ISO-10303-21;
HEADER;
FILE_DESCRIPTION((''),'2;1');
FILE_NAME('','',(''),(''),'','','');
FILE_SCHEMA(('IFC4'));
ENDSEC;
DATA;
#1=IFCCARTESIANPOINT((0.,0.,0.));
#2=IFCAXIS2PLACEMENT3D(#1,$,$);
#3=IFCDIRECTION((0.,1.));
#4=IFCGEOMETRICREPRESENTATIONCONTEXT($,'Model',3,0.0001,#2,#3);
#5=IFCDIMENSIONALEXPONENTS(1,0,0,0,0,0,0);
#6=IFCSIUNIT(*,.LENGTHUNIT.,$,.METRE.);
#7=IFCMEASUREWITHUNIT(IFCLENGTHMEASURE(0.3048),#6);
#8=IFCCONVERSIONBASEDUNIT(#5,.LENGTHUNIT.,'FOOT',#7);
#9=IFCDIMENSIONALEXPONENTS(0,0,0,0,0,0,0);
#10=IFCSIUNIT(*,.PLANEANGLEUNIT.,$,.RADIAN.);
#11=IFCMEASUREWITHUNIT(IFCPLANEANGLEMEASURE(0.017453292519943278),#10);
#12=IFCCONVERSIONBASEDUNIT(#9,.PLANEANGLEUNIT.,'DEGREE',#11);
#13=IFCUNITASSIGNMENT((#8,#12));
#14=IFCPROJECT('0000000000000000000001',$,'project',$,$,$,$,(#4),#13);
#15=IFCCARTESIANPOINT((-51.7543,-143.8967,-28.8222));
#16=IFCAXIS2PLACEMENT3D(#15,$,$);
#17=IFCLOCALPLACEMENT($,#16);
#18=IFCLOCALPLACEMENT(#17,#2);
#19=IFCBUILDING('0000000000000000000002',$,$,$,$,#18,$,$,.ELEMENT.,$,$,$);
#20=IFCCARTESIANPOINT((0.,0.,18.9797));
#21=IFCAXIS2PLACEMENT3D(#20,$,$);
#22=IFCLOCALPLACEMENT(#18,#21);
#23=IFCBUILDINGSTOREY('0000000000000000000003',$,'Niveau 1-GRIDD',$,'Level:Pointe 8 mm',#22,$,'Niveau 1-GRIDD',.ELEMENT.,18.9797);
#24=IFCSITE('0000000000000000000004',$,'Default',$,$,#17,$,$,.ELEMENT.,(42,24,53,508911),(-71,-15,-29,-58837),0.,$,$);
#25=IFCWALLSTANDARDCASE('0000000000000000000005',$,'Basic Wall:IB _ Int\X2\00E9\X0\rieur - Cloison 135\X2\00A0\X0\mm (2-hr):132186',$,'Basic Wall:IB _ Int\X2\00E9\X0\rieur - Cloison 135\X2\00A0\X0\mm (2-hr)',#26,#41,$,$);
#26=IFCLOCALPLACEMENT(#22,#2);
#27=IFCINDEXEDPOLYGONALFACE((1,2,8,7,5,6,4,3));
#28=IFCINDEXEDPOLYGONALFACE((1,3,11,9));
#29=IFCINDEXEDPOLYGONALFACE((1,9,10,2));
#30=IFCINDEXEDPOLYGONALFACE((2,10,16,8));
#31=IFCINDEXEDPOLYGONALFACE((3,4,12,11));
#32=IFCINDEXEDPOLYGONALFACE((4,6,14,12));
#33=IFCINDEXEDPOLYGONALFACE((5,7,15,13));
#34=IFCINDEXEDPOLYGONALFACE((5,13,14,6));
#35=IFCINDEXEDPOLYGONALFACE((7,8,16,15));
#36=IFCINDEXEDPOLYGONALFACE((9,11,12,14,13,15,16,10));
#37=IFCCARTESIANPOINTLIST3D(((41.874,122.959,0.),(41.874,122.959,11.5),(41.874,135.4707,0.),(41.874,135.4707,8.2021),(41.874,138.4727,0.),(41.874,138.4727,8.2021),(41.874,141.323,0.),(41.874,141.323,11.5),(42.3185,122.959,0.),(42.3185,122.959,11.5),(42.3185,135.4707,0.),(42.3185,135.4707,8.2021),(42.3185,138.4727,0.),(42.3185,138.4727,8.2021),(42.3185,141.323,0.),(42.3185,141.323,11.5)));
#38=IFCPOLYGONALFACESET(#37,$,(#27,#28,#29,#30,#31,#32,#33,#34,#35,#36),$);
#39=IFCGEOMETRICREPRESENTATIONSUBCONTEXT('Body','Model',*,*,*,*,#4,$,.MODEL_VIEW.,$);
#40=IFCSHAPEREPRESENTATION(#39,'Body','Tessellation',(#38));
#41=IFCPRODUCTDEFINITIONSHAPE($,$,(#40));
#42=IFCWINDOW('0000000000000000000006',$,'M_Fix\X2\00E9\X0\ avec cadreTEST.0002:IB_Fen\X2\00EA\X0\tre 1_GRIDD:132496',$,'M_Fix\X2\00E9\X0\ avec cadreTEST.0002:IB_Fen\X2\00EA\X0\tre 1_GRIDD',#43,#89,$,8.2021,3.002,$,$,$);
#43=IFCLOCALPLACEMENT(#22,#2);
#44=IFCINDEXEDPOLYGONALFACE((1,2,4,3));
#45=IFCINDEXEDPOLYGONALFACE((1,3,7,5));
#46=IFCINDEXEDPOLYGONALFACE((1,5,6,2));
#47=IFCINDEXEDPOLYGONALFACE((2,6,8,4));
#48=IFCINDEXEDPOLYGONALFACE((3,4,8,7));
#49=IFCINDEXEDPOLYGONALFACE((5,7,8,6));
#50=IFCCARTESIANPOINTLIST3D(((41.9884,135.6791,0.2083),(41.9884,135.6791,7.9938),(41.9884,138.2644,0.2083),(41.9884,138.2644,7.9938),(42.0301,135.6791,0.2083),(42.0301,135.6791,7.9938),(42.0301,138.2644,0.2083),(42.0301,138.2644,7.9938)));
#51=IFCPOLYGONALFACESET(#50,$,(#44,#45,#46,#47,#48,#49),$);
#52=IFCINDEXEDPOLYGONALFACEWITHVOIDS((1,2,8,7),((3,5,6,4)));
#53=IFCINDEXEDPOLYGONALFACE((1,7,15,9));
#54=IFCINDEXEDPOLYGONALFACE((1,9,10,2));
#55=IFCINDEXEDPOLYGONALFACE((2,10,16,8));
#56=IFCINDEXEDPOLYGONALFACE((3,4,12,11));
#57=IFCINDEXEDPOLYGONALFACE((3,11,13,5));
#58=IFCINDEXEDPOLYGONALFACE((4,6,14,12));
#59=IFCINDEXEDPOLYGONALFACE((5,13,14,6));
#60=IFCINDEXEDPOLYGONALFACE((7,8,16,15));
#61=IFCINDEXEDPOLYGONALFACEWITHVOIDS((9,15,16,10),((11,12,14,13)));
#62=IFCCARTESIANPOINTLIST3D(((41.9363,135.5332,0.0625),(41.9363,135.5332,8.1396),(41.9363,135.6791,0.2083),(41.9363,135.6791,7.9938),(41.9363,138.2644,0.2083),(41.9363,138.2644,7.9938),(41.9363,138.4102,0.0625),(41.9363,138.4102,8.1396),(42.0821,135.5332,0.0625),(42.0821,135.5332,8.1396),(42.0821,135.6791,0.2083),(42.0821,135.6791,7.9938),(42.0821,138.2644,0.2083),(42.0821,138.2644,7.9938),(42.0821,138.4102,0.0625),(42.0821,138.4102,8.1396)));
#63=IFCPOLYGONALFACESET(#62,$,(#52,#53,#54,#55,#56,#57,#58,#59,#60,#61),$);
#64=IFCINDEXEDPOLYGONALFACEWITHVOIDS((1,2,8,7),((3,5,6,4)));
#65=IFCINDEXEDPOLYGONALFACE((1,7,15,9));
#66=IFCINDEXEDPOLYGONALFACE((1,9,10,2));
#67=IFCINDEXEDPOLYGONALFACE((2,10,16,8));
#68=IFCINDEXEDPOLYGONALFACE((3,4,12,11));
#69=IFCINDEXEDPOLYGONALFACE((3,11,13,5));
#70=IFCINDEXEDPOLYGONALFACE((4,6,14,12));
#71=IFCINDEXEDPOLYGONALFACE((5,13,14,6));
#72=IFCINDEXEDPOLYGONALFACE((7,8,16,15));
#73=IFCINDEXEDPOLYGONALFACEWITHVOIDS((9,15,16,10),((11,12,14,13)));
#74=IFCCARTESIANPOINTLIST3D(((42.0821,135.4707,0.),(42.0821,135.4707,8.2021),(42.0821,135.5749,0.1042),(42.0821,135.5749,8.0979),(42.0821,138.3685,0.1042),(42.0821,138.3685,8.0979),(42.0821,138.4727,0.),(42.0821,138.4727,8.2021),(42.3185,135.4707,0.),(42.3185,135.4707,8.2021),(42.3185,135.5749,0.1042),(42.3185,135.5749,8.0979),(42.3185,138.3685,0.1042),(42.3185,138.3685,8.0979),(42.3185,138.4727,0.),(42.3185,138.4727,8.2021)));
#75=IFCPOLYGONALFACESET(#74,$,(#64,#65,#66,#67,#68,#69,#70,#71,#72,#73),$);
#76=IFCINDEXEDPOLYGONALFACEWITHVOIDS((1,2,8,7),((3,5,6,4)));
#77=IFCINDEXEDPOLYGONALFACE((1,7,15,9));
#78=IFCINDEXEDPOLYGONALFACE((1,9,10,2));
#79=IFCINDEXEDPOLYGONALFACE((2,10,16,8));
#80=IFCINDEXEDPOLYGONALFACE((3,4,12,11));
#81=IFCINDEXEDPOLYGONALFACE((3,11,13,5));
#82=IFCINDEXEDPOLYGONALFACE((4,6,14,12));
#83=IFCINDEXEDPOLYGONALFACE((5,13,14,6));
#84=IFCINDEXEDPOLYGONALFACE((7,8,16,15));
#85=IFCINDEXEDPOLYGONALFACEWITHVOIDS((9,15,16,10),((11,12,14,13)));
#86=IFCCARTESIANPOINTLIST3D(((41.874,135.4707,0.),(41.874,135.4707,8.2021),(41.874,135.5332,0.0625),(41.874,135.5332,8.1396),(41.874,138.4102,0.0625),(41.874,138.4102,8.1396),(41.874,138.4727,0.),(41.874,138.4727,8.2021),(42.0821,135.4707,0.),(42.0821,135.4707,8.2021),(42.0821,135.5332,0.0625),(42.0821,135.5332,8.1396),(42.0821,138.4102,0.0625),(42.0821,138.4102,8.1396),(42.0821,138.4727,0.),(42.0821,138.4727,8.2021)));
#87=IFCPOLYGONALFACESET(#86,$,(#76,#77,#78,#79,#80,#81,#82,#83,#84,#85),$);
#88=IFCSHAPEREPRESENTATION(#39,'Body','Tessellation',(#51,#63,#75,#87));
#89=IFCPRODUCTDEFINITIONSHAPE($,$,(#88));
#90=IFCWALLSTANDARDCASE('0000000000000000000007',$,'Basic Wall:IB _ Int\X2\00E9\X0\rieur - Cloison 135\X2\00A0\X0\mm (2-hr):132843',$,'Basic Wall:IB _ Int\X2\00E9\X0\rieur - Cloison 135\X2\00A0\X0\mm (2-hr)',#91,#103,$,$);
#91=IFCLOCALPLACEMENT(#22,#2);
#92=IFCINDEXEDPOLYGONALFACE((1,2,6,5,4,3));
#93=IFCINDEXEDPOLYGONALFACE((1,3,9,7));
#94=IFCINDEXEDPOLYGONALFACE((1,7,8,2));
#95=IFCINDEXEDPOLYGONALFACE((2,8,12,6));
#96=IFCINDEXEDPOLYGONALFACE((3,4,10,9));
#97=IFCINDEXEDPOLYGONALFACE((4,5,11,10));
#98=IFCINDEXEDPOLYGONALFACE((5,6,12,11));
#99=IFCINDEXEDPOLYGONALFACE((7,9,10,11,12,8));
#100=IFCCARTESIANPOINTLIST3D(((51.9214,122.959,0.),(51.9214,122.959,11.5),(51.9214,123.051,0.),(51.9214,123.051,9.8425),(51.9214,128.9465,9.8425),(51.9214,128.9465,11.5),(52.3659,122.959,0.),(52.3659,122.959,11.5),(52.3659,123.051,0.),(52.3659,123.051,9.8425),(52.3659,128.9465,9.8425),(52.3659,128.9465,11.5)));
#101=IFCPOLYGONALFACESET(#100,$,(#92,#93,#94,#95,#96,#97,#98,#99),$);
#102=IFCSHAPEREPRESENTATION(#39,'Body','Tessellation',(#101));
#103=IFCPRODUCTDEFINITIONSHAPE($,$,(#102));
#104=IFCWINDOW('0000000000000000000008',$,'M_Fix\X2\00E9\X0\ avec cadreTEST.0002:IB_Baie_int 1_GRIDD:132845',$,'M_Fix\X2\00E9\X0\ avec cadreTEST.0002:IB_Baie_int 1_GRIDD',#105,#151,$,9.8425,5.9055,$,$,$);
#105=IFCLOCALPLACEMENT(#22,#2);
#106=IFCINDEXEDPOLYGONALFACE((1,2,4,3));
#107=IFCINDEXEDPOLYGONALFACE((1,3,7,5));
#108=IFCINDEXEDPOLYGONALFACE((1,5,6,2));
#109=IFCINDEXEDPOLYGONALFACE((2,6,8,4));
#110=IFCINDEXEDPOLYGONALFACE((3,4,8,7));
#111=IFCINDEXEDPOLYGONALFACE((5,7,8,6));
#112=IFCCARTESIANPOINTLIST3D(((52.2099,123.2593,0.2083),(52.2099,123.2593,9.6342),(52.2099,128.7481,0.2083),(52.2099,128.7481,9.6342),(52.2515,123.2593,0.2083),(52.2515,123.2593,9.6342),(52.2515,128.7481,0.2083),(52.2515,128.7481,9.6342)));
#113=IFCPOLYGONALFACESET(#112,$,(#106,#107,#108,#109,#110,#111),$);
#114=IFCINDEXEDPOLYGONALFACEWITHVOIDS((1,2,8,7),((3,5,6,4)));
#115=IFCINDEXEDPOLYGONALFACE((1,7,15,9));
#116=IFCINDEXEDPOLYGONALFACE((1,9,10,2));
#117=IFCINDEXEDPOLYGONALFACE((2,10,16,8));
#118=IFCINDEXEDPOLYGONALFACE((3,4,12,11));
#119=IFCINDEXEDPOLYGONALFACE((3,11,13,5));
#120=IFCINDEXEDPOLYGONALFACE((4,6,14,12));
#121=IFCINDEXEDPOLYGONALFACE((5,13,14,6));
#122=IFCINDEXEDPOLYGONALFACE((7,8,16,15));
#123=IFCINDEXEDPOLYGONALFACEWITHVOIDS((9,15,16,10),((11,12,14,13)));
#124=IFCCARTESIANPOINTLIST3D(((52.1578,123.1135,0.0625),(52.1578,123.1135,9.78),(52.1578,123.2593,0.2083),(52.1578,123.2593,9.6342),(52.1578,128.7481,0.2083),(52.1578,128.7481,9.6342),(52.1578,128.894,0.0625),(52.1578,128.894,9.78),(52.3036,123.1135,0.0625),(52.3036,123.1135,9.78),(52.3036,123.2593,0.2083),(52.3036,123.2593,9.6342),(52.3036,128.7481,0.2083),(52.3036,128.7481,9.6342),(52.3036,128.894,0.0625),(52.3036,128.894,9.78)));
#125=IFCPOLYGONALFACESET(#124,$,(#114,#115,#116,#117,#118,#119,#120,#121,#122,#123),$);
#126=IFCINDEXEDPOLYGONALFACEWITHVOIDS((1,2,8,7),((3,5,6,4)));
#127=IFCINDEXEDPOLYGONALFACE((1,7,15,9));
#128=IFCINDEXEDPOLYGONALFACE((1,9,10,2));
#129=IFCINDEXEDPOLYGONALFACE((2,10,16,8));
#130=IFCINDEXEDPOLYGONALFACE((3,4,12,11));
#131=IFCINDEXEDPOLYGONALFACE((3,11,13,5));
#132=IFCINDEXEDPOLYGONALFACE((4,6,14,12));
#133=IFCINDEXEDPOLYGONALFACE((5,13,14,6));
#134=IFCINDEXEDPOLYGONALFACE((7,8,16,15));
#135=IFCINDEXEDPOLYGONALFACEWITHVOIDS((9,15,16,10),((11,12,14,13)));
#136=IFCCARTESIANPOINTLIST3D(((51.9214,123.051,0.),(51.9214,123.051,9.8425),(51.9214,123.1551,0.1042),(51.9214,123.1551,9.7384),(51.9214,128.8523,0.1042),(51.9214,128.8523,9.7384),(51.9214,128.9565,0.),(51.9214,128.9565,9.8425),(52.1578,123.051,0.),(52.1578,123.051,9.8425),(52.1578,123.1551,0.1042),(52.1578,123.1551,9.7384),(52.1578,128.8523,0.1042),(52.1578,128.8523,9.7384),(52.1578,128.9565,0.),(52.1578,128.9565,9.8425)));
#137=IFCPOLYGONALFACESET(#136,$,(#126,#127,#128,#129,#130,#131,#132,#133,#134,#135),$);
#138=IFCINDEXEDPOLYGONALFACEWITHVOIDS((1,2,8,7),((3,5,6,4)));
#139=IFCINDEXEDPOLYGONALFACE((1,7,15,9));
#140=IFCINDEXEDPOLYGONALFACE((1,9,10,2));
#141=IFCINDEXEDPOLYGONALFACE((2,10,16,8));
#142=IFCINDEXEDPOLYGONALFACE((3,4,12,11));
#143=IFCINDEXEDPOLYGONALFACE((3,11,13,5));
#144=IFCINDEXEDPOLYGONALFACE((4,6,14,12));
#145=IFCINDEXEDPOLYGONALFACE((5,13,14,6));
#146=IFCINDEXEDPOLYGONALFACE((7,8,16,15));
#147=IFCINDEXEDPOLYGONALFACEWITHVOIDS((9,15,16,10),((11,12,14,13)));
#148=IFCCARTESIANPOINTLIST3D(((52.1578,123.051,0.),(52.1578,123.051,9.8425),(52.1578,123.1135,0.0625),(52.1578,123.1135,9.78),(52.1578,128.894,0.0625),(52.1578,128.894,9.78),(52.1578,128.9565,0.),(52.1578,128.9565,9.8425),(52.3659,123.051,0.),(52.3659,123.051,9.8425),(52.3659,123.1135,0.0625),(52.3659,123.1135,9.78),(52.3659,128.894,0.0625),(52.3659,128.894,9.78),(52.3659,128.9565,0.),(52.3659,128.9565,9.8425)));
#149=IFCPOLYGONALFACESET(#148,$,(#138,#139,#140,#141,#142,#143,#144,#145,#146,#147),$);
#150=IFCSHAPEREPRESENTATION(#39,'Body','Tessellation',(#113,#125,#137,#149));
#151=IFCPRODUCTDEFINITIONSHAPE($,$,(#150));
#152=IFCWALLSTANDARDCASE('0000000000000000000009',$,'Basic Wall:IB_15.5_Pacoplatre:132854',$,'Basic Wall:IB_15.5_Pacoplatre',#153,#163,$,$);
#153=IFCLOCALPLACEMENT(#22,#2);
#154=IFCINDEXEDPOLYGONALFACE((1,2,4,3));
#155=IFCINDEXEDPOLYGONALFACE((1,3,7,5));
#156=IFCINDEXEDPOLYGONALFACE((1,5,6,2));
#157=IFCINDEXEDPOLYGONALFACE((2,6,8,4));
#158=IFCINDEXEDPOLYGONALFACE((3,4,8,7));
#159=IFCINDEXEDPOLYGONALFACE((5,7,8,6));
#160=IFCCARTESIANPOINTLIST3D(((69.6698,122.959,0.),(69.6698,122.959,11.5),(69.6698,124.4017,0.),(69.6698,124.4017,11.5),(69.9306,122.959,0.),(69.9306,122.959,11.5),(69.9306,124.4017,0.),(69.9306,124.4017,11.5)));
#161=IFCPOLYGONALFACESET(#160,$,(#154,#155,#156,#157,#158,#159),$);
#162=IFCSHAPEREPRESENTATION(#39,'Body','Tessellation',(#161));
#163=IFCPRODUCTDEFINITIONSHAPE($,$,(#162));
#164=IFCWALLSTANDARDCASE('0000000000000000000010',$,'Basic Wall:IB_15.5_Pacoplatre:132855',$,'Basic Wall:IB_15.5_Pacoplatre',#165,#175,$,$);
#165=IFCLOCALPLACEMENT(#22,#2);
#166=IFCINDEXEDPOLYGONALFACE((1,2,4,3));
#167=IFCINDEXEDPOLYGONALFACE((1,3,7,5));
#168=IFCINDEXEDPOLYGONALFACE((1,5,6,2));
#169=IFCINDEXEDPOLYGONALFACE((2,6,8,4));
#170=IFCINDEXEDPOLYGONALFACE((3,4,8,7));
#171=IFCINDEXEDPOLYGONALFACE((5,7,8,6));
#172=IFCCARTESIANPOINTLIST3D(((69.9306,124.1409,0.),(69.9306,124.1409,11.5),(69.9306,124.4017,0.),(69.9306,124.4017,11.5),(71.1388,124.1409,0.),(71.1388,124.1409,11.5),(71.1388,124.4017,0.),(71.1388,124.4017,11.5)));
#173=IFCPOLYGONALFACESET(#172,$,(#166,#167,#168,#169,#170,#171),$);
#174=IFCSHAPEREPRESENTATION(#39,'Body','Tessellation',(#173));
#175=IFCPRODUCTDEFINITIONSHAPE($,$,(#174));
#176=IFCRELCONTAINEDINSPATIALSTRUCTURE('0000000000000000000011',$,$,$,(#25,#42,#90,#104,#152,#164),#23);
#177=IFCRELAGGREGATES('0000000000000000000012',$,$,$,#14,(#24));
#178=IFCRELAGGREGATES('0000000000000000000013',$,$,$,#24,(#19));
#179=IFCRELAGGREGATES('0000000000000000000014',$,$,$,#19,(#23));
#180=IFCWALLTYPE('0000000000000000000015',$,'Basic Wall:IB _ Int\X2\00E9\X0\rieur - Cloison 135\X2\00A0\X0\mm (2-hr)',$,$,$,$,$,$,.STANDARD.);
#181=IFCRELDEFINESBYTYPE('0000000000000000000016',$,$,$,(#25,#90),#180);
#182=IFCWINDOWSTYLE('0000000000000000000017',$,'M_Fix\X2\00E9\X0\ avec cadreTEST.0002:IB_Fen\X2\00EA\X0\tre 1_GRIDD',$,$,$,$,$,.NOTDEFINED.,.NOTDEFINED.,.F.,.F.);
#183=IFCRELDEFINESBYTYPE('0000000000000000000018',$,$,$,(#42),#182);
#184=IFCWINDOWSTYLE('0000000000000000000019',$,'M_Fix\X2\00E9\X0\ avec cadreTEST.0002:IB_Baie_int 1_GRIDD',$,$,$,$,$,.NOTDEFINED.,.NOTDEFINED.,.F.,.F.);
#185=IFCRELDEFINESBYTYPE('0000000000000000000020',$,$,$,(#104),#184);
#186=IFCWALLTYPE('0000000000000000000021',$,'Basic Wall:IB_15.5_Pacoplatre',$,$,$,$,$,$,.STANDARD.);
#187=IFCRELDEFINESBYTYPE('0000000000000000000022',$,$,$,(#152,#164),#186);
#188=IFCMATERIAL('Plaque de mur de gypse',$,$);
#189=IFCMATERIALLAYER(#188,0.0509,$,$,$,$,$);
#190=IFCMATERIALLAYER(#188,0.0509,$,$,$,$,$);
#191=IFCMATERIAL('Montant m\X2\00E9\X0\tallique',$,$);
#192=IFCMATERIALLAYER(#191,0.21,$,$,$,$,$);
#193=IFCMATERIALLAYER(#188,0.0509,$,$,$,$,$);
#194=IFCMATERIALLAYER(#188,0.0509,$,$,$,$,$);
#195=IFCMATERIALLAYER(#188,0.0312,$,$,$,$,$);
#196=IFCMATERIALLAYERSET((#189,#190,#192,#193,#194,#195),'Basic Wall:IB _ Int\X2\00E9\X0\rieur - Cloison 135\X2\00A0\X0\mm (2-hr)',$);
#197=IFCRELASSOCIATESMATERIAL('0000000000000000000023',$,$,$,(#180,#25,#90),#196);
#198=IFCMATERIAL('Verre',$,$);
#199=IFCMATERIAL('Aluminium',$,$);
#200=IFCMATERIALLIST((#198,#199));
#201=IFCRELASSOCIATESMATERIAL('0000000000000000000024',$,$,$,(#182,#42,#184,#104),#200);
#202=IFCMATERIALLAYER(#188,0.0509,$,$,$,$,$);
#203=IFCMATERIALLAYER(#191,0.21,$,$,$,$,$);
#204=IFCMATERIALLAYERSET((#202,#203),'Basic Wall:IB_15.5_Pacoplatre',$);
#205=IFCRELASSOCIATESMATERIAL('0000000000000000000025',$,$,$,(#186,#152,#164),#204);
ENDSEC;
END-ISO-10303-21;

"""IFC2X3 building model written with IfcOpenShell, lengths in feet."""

from ifc_helpers import new_model, entity, si_unit, converted_unit, direction, frame, frame_2d, origin, origin_2d_with_axis, place, context, subcontext, project, spatial, polyline, rectangle, outline, extrude, source, transform, mapped, material, material_list, layer, layer_set, layer_usage, type_object, type_shapes, element, fill, save


model = new_model("IFC2X3")

# Units and contexts
model_context = context("Model", 3, precision=0.0001, world=origin(), true_north=direction((0.0, 1.0)))
body_context = subcontext(model_context, "Body", "Model", "MODEL_VIEW")
ifc_project = project(units=[converted_unit("LENGTHUNIT", "FOOT", entity("IfcLengthMeasure", 0.3048), si_unit("LENGTHUNIT", "METRE"), dimensions=[1, 0, 0, 0, 0, 0, 0]), converted_unit("PLANEANGLEUNIT", "DEGREE", entity("IfcPlaneAngleMeasure", 0.017453292519943278), si_unit("PLANEANGLEUNIT", "RADIAN"), dimensions=[0, 0, 0, 0, 0, 0, 0])], contexts=[model_context])

# Site, building, storey
site_placement = place(None, frame((-51.7543, -143.8967, -28.8222)))
site = spatial("IfcSite", under=ifc_project, at=site_placement, Name="Default", CompositionType="ELEMENT", RefLatitude=(42, 24, 53, 508911), RefLongitude=(-71, -15, -29, -58837), RefElevation=0.0)
building_placement = place(site_placement, origin())
building = spatial("IfcBuilding", under=site, at=building_placement, CompositionType="ELEMENT")
storey_placement = place(building_placement, frame((0.0, 0.0, 18.9797)))
storey = spatial("IfcBuildingStorey", under=building, at=storey_placement, Name="Niveau 1-GRIDD", ObjectType="Level:Pointe 8 mm", LongName="Niveau 1-GRIDD", CompositionType="ELEMENT", Elevation=18.9797)

# Shared definitions
ifc_material_1 = material(Name="Plaque de mur de gypse")
ifc_material_2 = material(Name="Montant métallique")
ifc_material_3 = material(Name="Verre")
ifc_material_4 = material(Name="Aluminium")
ifc_material_list = material_list([ifc_material_3, ifc_material_4])

# Shared definitions
ifc_layer_1 = layer(ifc_material_1, 0.0509)
ifc_layer_2 = layer(ifc_material_1, 0.0509)
ifc_layer_3 = layer(ifc_material_2, 0.21)
ifc_layer_4 = layer(ifc_material_1, 0.0509)
ifc_layer_5 = layer(ifc_material_1, 0.0509)
ifc_layer_6 = layer(ifc_material_1, 0.0312)
ifc_layer_set_1 = layer_set([ifc_layer_1, ifc_layer_2, ifc_layer_3, ifc_layer_4, ifc_layer_5, ifc_layer_6], Name="Basic Wall:IB _ Intérieur - Cloison 135 mm (2-hr)")
wall_type_1 = type_object("IfcWallType", Name="Basic Wall:IB _ Intérieur - Cloison 135 mm (2-hr)", PredefinedType="STANDARD", material=ifc_layer_set_1)

# Walls, openings, windows
ifc_layer_usage_1 = layer_usage(ifc_layer_set_1, "AXIS2", "NEGATIVE", 0.2223)
wall_1_placement = place(storey_placement, frame((42.0963, 122.959, 0.0), z_axis=(0.0, 0.0, 1.0), x_axis=(0.0, 1.0, 0.0)))
wall_1 = element("IfcWallStandardCase", 1, at=wall_1_placement, inside=storey, type_object=wall_type_1, material=ifc_layer_usage_1, Name="Basic Wall:IB _ Intérieur - Cloison 135 mm (2-hr):132186", ObjectType="Basic Wall:IB _ Intérieur - Cloison 135 mm (2-hr)", context=body_context, shape_type="SweptSolid", body=[
    extrude(rectangle(XDim=18.364, YDim=0.4446, at=frame_2d((9.182, 0.0), x_axis=(1.0, 0.0))), origin(), (0.0, 0.0, 1.0), 11.5),
])
opening_1_placement = place(wall_1_placement, frame((12.5117, -0.2223, 0.0)))
opening_1 = element("IfcOpeningElement", 2, at=opening_1_placement, cuts=wall_1, ObjectType="Opening", context=body_context, shape_type="SweptSolid", body=[
    extrude(rectangle(XDim=8.2021, YDim=3.002, at=frame_2d((4.101, 1.501), x_axis=(-1.0, 0.0))), frame((0.0, 0.0, 0.0), z_axis=(0.0, 1.0, 0.0), x_axis=(0.0, 0.0, 1.0)), (0.0, 0.0, 1.0), 0.4446),
])
window_style_1 = type_object("IfcWindowStyle", Name="M_Fixé avec cadreTEST.0002:IB_Fenêtre 1_GRIDD", ConstructionType="NOTDEFINED", OperationType="NOTDEFINED", ParameterTakesPrecedence=False, Sizeable=False, material=ifc_material_list)
shared_shape_1 = source(origin(), body_context, "Body", "SweptSolid", [
    extrude(rectangle(XDim=2.5853, YDim=0.0417, at=origin_2d_with_axis()), frame((1.751, 0.3093, 0.2083)), (0.0, 0.0, 1.0), 7.7854),
    extrude(outline(polyline([(-1.4385, -4.0385), (1.4385, -4.0385), (1.4385, 4.0385), (-1.4385, 4.0385), (-1.4385, -4.0385)]), holes=[polyline([(-1.2927, -3.8927), (-1.2927, 3.8927), (1.2927, 3.8927), (1.2927, -3.8927), (-1.2927, -3.8927)])]), frame((1.751, 0.3822, 4.101), z_axis=(0.0, -1.0, 0.0), x_axis=(-1.0, 0.0, 0.0)), (0.0, 0.0, 1.0), 0.1458),
    extrude(outline(polyline([(-1.501, -4.101), (1.501, -4.101), (1.501, 4.101), (-1.501, 4.101), (-1.501, -4.101)]), holes=[polyline([(-1.3968, -3.9969), (-1.3968, 3.9969), (1.3968, 3.9969), (1.3968, -3.9969), (-1.3968, -3.9969)])]), frame((1.751, 0.2364, 4.101), z_axis=(0.0, -1.0, 0.0), x_axis=(-1.0, 0.0, 0.0)), (0.0, 0.0, 1.0), 0.2364),
    extrude(outline(polyline([(-4.101, -1.501), (4.101, -1.501), (4.101, 1.501), (-4.101, 1.501), (-4.101, -1.501)]), holes=[polyline([(-4.0385, -1.4385), (-4.0385, 1.4385), (4.0385, 1.4385), (4.0385, -1.4385), (-4.0385, -1.4385)])]), frame((1.751, 0.4446, 4.101), z_axis=(0.0, -1.0, 0.0), x_axis=(0.0, 0.0, -1.0)), (0.0, 0.0, 1.0), 0.2082),
])
type_shapes(window_style_1, [shared_shape_1])
window_1_placement = place(opening_1_placement, frame((-0.25, 0.0, 0.0)))
window_1 = element("IfcWindow", 3, at=window_1_placement, inside=storey, type_object=window_style_1, material=ifc_material_list, Name="M_Fixé avec cadreTEST.0002:IB_Fenêtre 1_GRIDD:132496", ObjectType="M_Fixé avec cadreTEST.0002:IB_Fenêtre 1_GRIDD", OverallHeight=8.2021, OverallWidth=3.002, context=body_context, shape_type="MappedRepresentation", body=[
    mapped(shared_shape_1, transform((0.0, 0.0, 0.0), scale=1.0)),
])
fill(opening_1, window_1)
ifc_layer_usage_2 = layer_usage(ifc_layer_set_1, "AXIS2", "NEGATIVE", 0.2223)
wall_2_placement = place(storey_placement, frame((52.1437, 122.959, 0.0), z_axis=(0.0, 0.0, 1.0), x_axis=(0.0, 1.0, 0.0)))
wall_2 = element("IfcWallStandardCase", 4, at=wall_2_placement, inside=storey, type_object=wall_type_1, material=ifc_layer_usage_2, Name="Basic Wall:IB _ Intérieur - Cloison 135 mm (2-hr):132843", ObjectType="Basic Wall:IB _ Intérieur - Cloison 135 mm (2-hr)", context=body_context, shape_type="SweptSolid", body=[
    extrude(rectangle(XDim=5.9875, YDim=0.4446, at=frame_2d((2.9938, 0.0), x_axis=(-1.0, 0.0))), origin(), (0.0, 0.0, 1.0), 11.5),
])
opening_2_placement = place(wall_2_placement, frame((5.9975, 0.2223, 0.0)))
opening_2 = element("IfcOpeningElement", 5, at=opening_2_placement, cuts=wall_2, ObjectType="Opening", context=body_context, shape_type="SweptSolid", body=[
    extrude(rectangle(XDim=9.8425, YDim=5.9055, at=frame_2d((4.9213, 2.9528), x_axis=(-1.0, 0.0))), frame((0.0, 0.0, 0.0), z_axis=(0.0, -1.0, 0.0), x_axis=(0.0, 0.0, 1.0)), (0.0, 0.0, 1.0), 0.4446),
])
window_style_2 = type_object("IfcWindowStyle", Name="M_Fixé avec cadreTEST.0002:IB_Baie_int 1_GRIDD", ConstructionType="NOTDEFINED", OperationType="NOTDEFINED", ParameterTakesPrecedence=False, Sizeable=False, material=ifc_material_list)
shared_shape_2 = source(origin(), body_context, "Body", "SweptSolid", [
    extrude(rectangle(XDim=0.0417, YDim=5.4888, at=frame_2d((0.0, 0.0), x_axis=(1.0, 0.0))), frame((2.9528, 0.3093, 0.2083), z_axis=(0.0, 0.0, 1.0), x_axis=(0.0, 1.0, 0.0)), (0.0, 0.0, 1.0), 9.4259),
    extrude(outline(polyline([(-2.8903, -4.8588), (2.8903, -4.8588), (2.8903, 4.8588), (-2.8903, 4.8588), (-2.8903, -4.8588)]), holes=[polyline([(-2.7444, -4.7129), (-2.7444, 4.7129), (2.7444, 4.7129), (2.7444, -4.7129), (-2.7444, -4.7129)])]), frame((2.9528, 0.2364, 4.9213), z_axis=(0.0, 1.0, 0.0), x_axis=(1.0, 0.0, 0.0)), (0.0, 0.0, 1.0), 0.1458),
    extrude(outline(polyline([(-2.9528, -4.9213), (2.9528, -4.9213), (2.9528, 4.9213), (-2.9528, 4.9213), (-2.9528, -4.9213)]), holes=[polyline([(-2.8486, -4.8171), (-2.8486, 4.8171), (2.8486, 4.8171), (2.8486, -4.8171), (-2.8486, -4.8171)])]), frame((2.9528, 0.0, 4.9213), z_axis=(0.0, 1.0, 0.0), x_axis=(1.0, 0.0, 0.0)), (0.0, 0.0, 1.0), 0.2364),
    extrude(outline(polyline([(-4.9213, -2.9528), (4.9213, -2.9528), (4.9213, 2.9528), (-4.9213, 2.9528), (-4.9213, -2.9528)]), holes=[polyline([(-4.8588, -2.8903), (-4.8588, 2.8903), (4.8588, 2.8903), (4.8588, -2.8903), (-4.8588, -2.8903)])]), frame((2.9528, 0.2364, 4.9213), z_axis=(0.0, 1.0, 0.0), x_axis=(0.0, 0.0, -1.0)), (0.0, 0.0, 1.0), 0.2082),
])
type_shapes(window_style_2, [shared_shape_2])
window_2_placement = place(opening_2_placement, frame((0.0, 0.0, 0.0), z_axis=(0.0, 0.0, 1.0), x_axis=(-1.0, 0.0, 0.0)))
window_2 = element("IfcWindow", 6, at=window_2_placement, inside=storey, type_object=window_style_2, material=ifc_material_list, Name="M_Fixé avec cadreTEST.0002:IB_Baie_int 1_GRIDD:132845", ObjectType="M_Fixé avec cadreTEST.0002:IB_Baie_int 1_GRIDD", OverallHeight=9.8425, OverallWidth=5.9055, context=body_context, shape_type="MappedRepresentation", body=[
    mapped(shared_shape_2, transform((0.0, 0.0, 0.0), scale=1.0)),
])
fill(opening_2, window_2)

# Walls
ifc_layer_7 = layer(ifc_material_1, 0.0509)
ifc_layer_8 = layer(ifc_material_2, 0.21)
ifc_layer_set_2 = layer_set([ifc_layer_7, ifc_layer_8], Name="Basic Wall:IB_15.5_Pacoplatre")
ifc_layer_usage_3 = layer_usage(ifc_layer_set_2, "AXIS2", "NEGATIVE", 0.1304)
wall_type_2 = type_object("IfcWallType", Name="Basic Wall:IB_15.5_Pacoplatre", PredefinedType="STANDARD", material=ifc_layer_set_2)
wall_3_placement = place(storey_placement, frame((69.8002, 122.959, 0.0), z_axis=(0.0, 0.0, 1.0), x_axis=(0.0, 1.0, 0.0)))
element("IfcWallStandardCase", 7, at=wall_3_placement, inside=storey, type_object=wall_type_2, material=ifc_layer_usage_3, Name="Basic Wall:IB_15.5_Pacoplatre:132854", ObjectType="Basic Wall:IB_15.5_Pacoplatre", context=body_context, shape_type="SweptSolid", body=[
    extrude(rectangle(XDim=1.4427, YDim=0.2608, at=frame_2d((0.7214, 0.0), x_axis=(-1.0, 0.0))), origin(), (0.0, 0.0, 1.0), 11.5),
])
ifc_layer_usage_4 = layer_usage(ifc_layer_set_2, "AXIS2", "NEGATIVE", 0.1304)
wall_4_placement = place(storey_placement, frame((69.9306, 124.2713, 0.0)))
element("IfcWallStandardCase", 8, at=wall_4_placement, inside=storey, type_object=wall_type_2, material=ifc_layer_usage_4, Name="Basic Wall:IB_15.5_Pacoplatre:132855", ObjectType="Basic Wall:IB_15.5_Pacoplatre", context=body_context, shape_type="SweptSolid", body=[
    extrude(rectangle(XDim=1.2082, YDim=0.2608, at=frame_2d((0.6041, 0.0), x_axis=(-1.0, 0.0))), origin(), (0.0, 0.0, 1.0), 11.5),
])

save(model, "model.ifc")
